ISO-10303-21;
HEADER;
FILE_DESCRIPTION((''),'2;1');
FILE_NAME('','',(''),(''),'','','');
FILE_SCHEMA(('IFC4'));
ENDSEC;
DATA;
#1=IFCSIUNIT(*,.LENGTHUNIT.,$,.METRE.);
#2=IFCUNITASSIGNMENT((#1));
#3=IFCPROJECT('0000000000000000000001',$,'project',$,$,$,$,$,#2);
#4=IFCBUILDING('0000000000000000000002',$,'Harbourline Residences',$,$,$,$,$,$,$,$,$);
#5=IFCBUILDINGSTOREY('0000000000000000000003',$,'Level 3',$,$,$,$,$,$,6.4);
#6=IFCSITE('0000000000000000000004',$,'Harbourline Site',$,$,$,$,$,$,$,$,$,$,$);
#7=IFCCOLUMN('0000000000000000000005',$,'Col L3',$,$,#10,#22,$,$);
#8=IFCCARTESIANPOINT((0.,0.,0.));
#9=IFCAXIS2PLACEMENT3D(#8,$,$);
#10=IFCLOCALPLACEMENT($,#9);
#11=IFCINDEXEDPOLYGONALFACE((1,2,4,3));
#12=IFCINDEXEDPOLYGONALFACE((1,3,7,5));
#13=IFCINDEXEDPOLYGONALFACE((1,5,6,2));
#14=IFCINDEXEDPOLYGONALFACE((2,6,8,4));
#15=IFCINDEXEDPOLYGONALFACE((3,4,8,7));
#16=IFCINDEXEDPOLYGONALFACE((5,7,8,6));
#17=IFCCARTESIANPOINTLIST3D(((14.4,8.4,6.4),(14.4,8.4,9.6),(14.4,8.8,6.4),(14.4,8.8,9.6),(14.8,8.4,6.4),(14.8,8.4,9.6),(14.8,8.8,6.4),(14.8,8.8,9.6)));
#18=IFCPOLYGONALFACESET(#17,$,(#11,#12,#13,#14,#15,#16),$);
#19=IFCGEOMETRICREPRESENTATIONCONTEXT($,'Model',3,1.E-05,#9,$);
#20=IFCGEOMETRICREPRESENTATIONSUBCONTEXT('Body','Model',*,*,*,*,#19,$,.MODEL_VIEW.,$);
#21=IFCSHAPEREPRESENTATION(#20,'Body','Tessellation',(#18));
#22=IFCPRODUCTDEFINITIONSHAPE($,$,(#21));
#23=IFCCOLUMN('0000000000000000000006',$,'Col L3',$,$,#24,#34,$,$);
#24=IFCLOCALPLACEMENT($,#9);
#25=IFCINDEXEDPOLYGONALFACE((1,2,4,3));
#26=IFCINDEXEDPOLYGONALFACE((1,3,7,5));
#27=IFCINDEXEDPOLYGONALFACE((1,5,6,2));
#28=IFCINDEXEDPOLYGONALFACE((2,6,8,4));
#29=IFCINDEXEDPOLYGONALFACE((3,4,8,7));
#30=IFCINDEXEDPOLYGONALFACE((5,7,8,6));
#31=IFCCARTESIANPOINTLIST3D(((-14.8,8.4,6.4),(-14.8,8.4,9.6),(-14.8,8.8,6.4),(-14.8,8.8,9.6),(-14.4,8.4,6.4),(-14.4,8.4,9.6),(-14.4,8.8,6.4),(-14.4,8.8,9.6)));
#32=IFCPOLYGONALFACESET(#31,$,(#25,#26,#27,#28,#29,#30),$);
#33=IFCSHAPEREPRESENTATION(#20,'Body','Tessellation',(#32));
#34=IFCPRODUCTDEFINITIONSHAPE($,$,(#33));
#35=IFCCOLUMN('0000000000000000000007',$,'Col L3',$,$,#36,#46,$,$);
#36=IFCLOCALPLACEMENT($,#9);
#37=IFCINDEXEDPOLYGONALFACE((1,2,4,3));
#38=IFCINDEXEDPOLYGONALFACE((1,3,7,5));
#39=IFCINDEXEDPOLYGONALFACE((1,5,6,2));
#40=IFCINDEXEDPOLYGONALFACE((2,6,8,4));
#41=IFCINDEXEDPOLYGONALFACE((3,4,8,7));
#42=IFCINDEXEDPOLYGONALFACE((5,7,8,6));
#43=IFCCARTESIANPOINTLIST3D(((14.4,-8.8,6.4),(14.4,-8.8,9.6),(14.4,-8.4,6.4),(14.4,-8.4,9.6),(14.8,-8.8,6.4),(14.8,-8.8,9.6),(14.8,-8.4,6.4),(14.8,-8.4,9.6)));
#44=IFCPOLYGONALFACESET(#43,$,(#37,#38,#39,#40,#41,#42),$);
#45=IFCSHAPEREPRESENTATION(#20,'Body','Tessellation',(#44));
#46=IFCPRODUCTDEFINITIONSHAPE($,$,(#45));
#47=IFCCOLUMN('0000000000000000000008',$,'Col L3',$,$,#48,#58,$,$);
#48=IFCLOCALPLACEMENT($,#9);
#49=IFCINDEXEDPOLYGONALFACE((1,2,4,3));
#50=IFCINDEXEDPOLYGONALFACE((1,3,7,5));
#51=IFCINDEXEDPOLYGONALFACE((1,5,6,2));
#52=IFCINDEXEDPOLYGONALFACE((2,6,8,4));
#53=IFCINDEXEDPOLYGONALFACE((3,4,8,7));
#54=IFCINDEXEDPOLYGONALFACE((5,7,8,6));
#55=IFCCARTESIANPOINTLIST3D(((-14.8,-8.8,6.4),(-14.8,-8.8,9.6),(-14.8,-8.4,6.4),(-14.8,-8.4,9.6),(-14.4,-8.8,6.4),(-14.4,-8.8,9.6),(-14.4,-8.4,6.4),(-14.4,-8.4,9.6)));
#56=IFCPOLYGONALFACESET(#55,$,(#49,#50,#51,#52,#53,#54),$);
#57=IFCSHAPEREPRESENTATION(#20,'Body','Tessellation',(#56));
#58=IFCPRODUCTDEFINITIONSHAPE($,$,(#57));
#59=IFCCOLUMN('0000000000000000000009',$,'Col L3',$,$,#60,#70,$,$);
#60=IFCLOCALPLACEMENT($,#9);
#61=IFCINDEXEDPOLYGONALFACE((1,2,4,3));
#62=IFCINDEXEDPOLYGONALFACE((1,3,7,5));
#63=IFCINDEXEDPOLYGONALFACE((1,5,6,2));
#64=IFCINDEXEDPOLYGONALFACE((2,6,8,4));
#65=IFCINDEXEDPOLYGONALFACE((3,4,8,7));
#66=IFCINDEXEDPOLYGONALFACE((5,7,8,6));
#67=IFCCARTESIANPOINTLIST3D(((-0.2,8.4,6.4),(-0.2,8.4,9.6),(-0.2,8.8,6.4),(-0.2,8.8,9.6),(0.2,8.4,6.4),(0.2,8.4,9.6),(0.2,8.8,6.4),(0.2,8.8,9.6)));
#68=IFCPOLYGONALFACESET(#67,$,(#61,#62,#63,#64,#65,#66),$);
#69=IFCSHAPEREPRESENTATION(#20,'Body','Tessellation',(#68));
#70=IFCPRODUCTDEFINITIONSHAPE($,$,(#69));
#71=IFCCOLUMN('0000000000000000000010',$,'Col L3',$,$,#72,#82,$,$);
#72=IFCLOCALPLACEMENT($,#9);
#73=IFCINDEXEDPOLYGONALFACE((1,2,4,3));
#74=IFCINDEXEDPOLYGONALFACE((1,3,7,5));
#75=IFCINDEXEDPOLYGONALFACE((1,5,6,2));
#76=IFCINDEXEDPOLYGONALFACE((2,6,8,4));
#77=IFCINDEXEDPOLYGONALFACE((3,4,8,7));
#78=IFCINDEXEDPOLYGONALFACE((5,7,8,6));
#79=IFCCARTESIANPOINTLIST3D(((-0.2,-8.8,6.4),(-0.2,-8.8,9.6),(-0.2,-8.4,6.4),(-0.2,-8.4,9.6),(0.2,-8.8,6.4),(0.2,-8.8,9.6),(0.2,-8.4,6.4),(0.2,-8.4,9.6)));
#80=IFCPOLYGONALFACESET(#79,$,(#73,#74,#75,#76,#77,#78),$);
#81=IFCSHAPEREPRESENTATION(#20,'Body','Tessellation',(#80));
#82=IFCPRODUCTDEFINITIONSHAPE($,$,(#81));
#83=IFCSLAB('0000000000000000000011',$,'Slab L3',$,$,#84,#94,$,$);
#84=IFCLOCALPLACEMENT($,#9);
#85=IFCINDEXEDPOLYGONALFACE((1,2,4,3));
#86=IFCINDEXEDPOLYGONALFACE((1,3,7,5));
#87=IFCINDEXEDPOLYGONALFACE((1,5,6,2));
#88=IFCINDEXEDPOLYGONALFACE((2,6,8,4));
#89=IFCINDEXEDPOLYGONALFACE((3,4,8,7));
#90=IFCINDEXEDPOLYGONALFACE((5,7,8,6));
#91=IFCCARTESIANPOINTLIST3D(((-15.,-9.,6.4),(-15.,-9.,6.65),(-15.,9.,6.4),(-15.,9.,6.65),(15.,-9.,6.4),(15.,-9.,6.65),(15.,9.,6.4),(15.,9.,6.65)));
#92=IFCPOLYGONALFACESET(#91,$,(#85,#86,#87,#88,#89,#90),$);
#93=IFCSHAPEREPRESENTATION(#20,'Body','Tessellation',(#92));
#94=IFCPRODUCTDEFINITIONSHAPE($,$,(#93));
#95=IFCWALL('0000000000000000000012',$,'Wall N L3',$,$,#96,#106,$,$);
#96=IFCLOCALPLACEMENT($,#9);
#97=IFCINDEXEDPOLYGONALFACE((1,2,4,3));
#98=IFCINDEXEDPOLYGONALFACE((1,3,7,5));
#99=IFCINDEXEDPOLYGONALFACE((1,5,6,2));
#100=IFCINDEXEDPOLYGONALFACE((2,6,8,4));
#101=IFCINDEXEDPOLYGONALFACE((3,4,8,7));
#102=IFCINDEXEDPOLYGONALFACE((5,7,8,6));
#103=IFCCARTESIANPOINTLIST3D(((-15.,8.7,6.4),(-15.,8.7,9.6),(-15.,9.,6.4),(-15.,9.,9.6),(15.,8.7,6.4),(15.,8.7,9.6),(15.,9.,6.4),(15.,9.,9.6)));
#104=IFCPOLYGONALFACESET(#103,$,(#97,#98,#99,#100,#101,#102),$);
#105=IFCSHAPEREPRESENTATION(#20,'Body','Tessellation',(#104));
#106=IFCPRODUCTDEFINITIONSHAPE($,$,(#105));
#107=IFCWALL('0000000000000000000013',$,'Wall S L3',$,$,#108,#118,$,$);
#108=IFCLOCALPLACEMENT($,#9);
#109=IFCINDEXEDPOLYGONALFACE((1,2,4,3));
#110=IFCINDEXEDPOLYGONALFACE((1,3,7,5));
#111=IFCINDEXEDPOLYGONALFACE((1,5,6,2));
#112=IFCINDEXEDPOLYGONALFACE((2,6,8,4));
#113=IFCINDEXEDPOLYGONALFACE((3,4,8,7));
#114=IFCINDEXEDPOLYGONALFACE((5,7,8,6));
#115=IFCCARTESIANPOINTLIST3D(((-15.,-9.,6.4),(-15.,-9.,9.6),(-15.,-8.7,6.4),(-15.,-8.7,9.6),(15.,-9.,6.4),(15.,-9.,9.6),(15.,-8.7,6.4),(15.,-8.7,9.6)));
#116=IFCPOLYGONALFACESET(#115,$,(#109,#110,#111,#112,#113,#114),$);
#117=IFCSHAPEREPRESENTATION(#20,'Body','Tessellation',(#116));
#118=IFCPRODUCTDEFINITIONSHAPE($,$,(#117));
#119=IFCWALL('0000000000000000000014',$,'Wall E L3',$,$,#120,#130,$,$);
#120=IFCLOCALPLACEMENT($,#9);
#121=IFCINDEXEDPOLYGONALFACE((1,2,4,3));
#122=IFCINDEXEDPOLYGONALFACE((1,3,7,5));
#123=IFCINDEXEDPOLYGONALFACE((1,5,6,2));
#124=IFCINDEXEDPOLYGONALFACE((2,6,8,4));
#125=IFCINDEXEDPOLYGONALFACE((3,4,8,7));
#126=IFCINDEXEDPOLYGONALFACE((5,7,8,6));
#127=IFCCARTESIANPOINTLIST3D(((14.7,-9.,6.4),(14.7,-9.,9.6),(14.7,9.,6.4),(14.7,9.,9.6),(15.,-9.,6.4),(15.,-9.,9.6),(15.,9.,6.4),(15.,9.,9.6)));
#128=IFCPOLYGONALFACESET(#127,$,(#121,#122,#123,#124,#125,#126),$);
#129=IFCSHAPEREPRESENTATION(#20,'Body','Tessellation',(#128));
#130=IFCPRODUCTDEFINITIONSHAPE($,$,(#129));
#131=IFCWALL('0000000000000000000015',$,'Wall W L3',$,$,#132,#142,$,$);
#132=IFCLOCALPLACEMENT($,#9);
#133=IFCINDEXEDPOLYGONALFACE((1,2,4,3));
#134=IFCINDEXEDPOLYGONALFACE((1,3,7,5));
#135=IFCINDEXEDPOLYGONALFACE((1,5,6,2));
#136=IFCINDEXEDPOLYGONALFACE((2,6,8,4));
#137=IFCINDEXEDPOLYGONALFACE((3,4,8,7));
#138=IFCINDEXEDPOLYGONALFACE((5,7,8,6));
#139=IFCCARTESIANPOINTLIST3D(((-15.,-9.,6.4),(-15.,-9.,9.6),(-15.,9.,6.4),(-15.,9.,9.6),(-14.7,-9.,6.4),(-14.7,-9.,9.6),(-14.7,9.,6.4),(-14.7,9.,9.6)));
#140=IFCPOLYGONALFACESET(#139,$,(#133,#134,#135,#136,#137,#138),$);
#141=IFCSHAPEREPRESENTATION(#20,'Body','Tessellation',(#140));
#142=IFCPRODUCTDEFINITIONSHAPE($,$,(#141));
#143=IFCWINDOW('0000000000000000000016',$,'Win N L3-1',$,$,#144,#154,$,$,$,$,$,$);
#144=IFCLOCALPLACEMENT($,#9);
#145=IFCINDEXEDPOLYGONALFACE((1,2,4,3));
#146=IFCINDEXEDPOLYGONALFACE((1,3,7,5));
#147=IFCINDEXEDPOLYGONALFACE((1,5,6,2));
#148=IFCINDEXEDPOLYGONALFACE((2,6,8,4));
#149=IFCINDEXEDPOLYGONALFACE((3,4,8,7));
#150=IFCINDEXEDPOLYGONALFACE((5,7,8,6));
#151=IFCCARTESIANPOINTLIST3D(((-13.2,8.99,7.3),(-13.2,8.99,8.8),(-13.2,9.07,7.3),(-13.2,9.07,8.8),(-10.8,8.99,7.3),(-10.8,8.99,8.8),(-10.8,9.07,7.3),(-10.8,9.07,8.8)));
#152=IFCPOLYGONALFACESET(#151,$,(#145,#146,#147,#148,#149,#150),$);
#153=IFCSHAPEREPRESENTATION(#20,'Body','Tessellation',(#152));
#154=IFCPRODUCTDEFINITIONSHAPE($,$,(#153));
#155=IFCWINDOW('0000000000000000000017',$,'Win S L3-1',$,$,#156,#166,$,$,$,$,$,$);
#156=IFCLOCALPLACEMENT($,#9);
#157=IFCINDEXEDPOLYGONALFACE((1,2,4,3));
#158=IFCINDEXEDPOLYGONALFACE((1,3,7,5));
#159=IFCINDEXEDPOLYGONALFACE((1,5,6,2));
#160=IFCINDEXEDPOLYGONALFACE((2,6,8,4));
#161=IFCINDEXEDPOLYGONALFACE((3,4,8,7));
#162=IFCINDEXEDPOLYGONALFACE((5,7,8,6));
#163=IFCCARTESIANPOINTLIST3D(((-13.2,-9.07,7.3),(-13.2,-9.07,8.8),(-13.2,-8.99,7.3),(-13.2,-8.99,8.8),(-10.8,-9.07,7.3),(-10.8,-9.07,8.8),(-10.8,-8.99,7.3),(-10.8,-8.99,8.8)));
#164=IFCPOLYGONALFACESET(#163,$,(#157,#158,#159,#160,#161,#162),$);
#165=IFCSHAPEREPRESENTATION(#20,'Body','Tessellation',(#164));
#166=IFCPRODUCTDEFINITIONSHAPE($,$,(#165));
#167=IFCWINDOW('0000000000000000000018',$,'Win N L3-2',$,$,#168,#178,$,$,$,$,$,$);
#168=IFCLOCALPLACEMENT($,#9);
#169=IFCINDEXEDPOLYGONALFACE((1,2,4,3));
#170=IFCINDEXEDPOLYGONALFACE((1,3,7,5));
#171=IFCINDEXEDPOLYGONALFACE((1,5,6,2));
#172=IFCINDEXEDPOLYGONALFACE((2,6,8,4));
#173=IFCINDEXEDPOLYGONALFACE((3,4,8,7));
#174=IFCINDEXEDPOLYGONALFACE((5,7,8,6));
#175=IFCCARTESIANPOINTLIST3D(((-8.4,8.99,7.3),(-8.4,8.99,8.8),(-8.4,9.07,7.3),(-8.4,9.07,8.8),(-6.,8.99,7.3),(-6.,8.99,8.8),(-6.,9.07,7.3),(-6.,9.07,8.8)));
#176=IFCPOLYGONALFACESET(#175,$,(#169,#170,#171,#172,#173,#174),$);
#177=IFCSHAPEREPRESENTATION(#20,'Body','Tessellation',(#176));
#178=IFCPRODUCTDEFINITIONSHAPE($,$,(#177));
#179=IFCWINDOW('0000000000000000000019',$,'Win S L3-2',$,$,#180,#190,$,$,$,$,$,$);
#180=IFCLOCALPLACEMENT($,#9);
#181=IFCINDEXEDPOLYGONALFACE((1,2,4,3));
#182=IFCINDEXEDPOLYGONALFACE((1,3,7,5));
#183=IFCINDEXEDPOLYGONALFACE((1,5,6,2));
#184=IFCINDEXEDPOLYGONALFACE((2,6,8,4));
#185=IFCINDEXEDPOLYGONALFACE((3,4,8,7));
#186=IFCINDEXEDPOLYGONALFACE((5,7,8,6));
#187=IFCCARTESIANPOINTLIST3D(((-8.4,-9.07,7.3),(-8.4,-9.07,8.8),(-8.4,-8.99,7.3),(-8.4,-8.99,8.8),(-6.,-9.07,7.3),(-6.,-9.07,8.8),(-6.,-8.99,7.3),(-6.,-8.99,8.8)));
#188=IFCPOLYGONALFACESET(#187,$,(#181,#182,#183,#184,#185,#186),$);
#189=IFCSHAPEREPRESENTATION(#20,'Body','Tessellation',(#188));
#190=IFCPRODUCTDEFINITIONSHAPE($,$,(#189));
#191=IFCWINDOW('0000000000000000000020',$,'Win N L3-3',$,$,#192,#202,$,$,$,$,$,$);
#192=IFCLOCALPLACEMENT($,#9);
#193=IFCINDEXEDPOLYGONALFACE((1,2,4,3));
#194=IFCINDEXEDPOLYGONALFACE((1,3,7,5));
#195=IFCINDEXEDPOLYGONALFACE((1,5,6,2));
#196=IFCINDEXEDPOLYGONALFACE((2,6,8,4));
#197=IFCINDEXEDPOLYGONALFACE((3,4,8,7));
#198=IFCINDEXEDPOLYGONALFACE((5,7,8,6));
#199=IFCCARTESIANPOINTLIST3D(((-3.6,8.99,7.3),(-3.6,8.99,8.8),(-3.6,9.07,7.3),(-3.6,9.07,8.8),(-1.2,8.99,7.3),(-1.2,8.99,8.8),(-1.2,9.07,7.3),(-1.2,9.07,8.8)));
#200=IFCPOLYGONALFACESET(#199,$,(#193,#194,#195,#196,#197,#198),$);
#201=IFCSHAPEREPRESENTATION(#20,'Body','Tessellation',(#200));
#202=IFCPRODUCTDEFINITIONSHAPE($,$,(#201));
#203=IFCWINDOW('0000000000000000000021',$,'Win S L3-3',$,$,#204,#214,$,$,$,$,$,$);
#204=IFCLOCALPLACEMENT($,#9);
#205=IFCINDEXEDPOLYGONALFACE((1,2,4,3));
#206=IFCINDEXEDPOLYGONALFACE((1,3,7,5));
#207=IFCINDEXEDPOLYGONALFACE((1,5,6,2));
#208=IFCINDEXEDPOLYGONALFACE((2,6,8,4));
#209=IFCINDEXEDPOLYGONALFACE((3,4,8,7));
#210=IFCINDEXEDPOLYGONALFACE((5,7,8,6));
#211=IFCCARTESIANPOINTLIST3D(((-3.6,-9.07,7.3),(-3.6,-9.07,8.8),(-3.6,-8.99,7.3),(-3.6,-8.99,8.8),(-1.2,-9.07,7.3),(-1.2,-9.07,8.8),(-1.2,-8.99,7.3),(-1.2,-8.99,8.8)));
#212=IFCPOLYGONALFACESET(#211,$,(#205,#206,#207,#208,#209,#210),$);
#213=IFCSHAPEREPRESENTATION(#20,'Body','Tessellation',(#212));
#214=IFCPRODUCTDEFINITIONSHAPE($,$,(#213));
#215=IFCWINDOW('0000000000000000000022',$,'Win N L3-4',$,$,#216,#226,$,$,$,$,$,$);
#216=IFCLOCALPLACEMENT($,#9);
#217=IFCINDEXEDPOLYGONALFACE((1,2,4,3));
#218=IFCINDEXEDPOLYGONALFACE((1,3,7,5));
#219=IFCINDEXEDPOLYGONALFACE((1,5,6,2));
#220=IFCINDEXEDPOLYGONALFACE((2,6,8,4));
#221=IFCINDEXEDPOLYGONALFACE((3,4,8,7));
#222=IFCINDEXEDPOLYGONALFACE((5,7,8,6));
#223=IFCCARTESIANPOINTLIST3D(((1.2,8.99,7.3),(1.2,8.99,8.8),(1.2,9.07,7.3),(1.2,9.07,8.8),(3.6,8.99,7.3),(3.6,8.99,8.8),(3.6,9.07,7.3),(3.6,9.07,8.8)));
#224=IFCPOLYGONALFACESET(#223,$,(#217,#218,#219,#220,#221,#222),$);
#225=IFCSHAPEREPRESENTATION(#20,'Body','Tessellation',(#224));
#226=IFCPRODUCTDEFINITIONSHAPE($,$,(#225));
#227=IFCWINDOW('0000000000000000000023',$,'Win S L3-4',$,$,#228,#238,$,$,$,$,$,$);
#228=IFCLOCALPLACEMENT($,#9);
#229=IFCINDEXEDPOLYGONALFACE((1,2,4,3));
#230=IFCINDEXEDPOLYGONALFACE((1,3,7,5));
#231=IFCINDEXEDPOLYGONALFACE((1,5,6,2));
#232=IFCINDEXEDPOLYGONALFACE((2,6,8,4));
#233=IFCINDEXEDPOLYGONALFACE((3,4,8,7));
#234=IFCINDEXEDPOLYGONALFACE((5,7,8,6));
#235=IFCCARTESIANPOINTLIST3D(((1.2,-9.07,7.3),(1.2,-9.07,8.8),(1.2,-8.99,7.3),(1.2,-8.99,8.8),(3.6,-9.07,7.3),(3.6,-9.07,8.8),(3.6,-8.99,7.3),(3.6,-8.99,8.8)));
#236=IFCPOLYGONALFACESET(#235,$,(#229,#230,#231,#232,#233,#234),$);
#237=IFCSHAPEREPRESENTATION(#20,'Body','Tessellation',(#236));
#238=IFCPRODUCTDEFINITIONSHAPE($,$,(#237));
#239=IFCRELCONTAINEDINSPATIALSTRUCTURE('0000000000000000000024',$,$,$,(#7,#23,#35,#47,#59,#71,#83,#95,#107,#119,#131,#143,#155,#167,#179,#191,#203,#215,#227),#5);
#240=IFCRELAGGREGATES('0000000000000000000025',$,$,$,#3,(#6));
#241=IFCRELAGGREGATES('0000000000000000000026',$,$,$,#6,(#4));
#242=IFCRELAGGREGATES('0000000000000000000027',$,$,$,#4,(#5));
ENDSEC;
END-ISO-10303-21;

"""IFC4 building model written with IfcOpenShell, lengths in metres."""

from ifc_helpers import new_model, si_unit, frame, frame_2d, origin, origin_2d, context, subcontext, project, spatial, rectangle, extrude, element, save


model = new_model("IFC4")

# Units and contexts
model_context = context("Model", 3, precision=1e-05, world=origin())
body_context = subcontext(model_context, "Body", "Model", "MODEL_VIEW")
ifc_project = project(units=[si_unit("LENGTHUNIT", "METRE")])

# Site, building, storey
site = spatial("IfcSite", under=ifc_project, Name="Harbourline Site")
building = spatial("IfcBuilding", under=site, Name="Harbourline Residences")
storey = spatial("IfcBuildingStorey", under=building, Name="Level 3", Elevation=6.4)

# Columns
element("IfcColumn", 1, inside=storey, Name="Col L3", context=body_context, shape_type="SweptSolid", body=[
    extrude(rectangle(XDim=0.4, YDim=0.4, at=frame_2d((14.6, 8.6))), frame((0.0, 0.0, 6.4)), (0.0, 0.0, 1.0), 3.2),
])
element("IfcColumn", 2, inside=storey, Name="Col L3", context=body_context, shape_type="SweptSolid", body=[
    extrude(rectangle(XDim=0.4, YDim=0.4, at=frame_2d((-14.6, 8.6))), frame((0.0, 0.0, 6.4)), (0.0, 0.0, 1.0), 3.2),
])
element("IfcColumn", 3, inside=storey, Name="Col L3", context=body_context, shape_type="SweptSolid", body=[
    extrude(rectangle(XDim=0.4, YDim=0.4, at=frame_2d((14.6, -8.6))), frame((0.0, 0.0, 6.4)), (0.0, 0.0, 1.0), 3.2),
])
element("IfcColumn", 4, inside=storey, Name="Col L3", context=body_context, shape_type="SweptSolid", body=[
    extrude(rectangle(XDim=0.4, YDim=0.4, at=frame_2d((-14.6, -8.6))), frame((0.0, 0.0, 6.4)), (0.0, 0.0, 1.0), 3.2),
])
element("IfcColumn", 5, inside=storey, Name="Col L3", context=body_context, shape_type="SweptSolid", body=[
    extrude(rectangle(XDim=0.4, YDim=0.4, at=frame_2d((0.0, 8.6))), frame((0.0, 0.0, 6.4)), (0.0, 0.0, 1.0), 3.2),
])
element("IfcColumn", 6, inside=storey, Name="Col L3", context=body_context, shape_type="SweptSolid", body=[
    extrude(rectangle(XDim=0.4, YDim=0.4, at=frame_2d((0.0, -8.6))), frame((0.0, 0.0, 6.4)), (0.0, 0.0, 1.0), 3.2),
])

# Slab
element("IfcSlab", 7, inside=storey, Name="Slab L3", context=body_context, shape_type="SweptSolid", body=[
    extrude(rectangle(XDim=30.0, YDim=18.0, at=origin_2d()), frame((0.0, 0.0, 6.4)), (0.0, 0.0, 1.0), 0.25),
])

# Walls
element("IfcWall", 8, inside=storey, Name="Wall N L3", context=body_context, shape_type="SweptSolid", body=[
    extrude(rectangle(XDim=30.0, YDim=0.3, at=frame_2d((0.0, 8.85))), frame((0.0, 0.0, 6.4)), (0.0, 0.0, 1.0), 3.2),
])
element("IfcWall", 9, inside=storey, Name="Wall S L3", context=body_context, shape_type="SweptSolid", body=[
    extrude(rectangle(XDim=30.0, YDim=0.3, at=frame_2d((0.0, -8.85))), frame((0.0, 0.0, 6.4)), (0.0, 0.0, 1.0), 3.2),
])
element("IfcWall", 10, inside=storey, Name="Wall E L3", context=body_context, shape_type="SweptSolid", body=[
    extrude(rectangle(XDim=0.3, YDim=18.0, at=frame_2d((14.85, 0.0))), frame((0.0, 0.0, 6.4)), (0.0, 0.0, 1.0), 3.2),
])
element("IfcWall", 11, inside=storey, Name="Wall W L3", context=body_context, shape_type="SweptSolid", body=[
    extrude(rectangle(XDim=0.3, YDim=18.0, at=frame_2d((-14.85, 0.0))), frame((0.0, 0.0, 6.4)), (0.0, 0.0, 1.0), 3.2),
])

# Windows
element("IfcWindow", 12, inside=storey, Name="Win N L3-1", context=body_context, shape_type="SweptSolid", body=[
    extrude(rectangle(XDim=2.4, YDim=0.08, at=frame_2d((-12.0, 9.03))), frame((0.0, 0.0, 7.3)), (0.0, 0.0, 1.0), 1.5),
])
element("IfcWindow", 13, inside=storey, Name="Win S L3-1", context=body_context, shape_type="SweptSolid", body=[
    extrude(rectangle(XDim=2.4, YDim=0.08, at=frame_2d((-12.0, -9.03))), frame((0.0, 0.0, 7.3)), (0.0, 0.0, 1.0), 1.5),
])
element("IfcWindow", 14, inside=storey, Name="Win N L3-2", context=body_context, shape_type="SweptSolid", body=[
    extrude(rectangle(XDim=2.4, YDim=0.08, at=frame_2d((-7.2, 9.03))), frame((0.0, 0.0, 7.3)), (0.0, 0.0, 1.0), 1.5),
])
element("IfcWindow", 15, inside=storey, Name="Win S L3-2", context=body_context, shape_type="SweptSolid", body=[
    extrude(rectangle(XDim=2.4, YDim=0.08, at=frame_2d((-7.2, -9.03))), frame((0.0, 0.0, 7.3)), (0.0, 0.0, 1.0), 1.5),
])
element("IfcWindow", 16, inside=storey, Name="Win N L3-3", context=body_context, shape_type="SweptSolid", body=[
    extrude(rectangle(XDim=2.4, YDim=0.08, at=frame_2d((-2.4, 9.03))), frame((0.0, 0.0, 7.3)), (0.0, 0.0, 1.0), 1.5),
])
element("IfcWindow", 17, inside=storey, Name="Win S L3-3", context=body_context, shape_type="SweptSolid", body=[
    extrude(rectangle(XDim=2.4, YDim=0.08, at=frame_2d((-2.4, -9.03))), frame((0.0, 0.0, 7.3)), (0.0, 0.0, 1.0), 1.5),
])
element("IfcWindow", 18, inside=storey, Name="Win N L3-4", context=body_context, shape_type="SweptSolid", body=[
    extrude(rectangle(XDim=2.4, YDim=0.08, at=frame_2d((2.4, 9.03))), frame((0.0, 0.0, 7.3)), (0.0, 0.0, 1.0), 1.5),
])
element("IfcWindow", 19, inside=storey, Name="Win S L3-4", context=body_context, shape_type="SweptSolid", body=[
    extrude(rectangle(XDim=2.4, YDim=0.08, at=frame_2d((2.4, -9.03))), frame((0.0, 0.0, 7.3)), (0.0, 0.0, 1.0), 1.5),
])

save(model, "model.ifc")
